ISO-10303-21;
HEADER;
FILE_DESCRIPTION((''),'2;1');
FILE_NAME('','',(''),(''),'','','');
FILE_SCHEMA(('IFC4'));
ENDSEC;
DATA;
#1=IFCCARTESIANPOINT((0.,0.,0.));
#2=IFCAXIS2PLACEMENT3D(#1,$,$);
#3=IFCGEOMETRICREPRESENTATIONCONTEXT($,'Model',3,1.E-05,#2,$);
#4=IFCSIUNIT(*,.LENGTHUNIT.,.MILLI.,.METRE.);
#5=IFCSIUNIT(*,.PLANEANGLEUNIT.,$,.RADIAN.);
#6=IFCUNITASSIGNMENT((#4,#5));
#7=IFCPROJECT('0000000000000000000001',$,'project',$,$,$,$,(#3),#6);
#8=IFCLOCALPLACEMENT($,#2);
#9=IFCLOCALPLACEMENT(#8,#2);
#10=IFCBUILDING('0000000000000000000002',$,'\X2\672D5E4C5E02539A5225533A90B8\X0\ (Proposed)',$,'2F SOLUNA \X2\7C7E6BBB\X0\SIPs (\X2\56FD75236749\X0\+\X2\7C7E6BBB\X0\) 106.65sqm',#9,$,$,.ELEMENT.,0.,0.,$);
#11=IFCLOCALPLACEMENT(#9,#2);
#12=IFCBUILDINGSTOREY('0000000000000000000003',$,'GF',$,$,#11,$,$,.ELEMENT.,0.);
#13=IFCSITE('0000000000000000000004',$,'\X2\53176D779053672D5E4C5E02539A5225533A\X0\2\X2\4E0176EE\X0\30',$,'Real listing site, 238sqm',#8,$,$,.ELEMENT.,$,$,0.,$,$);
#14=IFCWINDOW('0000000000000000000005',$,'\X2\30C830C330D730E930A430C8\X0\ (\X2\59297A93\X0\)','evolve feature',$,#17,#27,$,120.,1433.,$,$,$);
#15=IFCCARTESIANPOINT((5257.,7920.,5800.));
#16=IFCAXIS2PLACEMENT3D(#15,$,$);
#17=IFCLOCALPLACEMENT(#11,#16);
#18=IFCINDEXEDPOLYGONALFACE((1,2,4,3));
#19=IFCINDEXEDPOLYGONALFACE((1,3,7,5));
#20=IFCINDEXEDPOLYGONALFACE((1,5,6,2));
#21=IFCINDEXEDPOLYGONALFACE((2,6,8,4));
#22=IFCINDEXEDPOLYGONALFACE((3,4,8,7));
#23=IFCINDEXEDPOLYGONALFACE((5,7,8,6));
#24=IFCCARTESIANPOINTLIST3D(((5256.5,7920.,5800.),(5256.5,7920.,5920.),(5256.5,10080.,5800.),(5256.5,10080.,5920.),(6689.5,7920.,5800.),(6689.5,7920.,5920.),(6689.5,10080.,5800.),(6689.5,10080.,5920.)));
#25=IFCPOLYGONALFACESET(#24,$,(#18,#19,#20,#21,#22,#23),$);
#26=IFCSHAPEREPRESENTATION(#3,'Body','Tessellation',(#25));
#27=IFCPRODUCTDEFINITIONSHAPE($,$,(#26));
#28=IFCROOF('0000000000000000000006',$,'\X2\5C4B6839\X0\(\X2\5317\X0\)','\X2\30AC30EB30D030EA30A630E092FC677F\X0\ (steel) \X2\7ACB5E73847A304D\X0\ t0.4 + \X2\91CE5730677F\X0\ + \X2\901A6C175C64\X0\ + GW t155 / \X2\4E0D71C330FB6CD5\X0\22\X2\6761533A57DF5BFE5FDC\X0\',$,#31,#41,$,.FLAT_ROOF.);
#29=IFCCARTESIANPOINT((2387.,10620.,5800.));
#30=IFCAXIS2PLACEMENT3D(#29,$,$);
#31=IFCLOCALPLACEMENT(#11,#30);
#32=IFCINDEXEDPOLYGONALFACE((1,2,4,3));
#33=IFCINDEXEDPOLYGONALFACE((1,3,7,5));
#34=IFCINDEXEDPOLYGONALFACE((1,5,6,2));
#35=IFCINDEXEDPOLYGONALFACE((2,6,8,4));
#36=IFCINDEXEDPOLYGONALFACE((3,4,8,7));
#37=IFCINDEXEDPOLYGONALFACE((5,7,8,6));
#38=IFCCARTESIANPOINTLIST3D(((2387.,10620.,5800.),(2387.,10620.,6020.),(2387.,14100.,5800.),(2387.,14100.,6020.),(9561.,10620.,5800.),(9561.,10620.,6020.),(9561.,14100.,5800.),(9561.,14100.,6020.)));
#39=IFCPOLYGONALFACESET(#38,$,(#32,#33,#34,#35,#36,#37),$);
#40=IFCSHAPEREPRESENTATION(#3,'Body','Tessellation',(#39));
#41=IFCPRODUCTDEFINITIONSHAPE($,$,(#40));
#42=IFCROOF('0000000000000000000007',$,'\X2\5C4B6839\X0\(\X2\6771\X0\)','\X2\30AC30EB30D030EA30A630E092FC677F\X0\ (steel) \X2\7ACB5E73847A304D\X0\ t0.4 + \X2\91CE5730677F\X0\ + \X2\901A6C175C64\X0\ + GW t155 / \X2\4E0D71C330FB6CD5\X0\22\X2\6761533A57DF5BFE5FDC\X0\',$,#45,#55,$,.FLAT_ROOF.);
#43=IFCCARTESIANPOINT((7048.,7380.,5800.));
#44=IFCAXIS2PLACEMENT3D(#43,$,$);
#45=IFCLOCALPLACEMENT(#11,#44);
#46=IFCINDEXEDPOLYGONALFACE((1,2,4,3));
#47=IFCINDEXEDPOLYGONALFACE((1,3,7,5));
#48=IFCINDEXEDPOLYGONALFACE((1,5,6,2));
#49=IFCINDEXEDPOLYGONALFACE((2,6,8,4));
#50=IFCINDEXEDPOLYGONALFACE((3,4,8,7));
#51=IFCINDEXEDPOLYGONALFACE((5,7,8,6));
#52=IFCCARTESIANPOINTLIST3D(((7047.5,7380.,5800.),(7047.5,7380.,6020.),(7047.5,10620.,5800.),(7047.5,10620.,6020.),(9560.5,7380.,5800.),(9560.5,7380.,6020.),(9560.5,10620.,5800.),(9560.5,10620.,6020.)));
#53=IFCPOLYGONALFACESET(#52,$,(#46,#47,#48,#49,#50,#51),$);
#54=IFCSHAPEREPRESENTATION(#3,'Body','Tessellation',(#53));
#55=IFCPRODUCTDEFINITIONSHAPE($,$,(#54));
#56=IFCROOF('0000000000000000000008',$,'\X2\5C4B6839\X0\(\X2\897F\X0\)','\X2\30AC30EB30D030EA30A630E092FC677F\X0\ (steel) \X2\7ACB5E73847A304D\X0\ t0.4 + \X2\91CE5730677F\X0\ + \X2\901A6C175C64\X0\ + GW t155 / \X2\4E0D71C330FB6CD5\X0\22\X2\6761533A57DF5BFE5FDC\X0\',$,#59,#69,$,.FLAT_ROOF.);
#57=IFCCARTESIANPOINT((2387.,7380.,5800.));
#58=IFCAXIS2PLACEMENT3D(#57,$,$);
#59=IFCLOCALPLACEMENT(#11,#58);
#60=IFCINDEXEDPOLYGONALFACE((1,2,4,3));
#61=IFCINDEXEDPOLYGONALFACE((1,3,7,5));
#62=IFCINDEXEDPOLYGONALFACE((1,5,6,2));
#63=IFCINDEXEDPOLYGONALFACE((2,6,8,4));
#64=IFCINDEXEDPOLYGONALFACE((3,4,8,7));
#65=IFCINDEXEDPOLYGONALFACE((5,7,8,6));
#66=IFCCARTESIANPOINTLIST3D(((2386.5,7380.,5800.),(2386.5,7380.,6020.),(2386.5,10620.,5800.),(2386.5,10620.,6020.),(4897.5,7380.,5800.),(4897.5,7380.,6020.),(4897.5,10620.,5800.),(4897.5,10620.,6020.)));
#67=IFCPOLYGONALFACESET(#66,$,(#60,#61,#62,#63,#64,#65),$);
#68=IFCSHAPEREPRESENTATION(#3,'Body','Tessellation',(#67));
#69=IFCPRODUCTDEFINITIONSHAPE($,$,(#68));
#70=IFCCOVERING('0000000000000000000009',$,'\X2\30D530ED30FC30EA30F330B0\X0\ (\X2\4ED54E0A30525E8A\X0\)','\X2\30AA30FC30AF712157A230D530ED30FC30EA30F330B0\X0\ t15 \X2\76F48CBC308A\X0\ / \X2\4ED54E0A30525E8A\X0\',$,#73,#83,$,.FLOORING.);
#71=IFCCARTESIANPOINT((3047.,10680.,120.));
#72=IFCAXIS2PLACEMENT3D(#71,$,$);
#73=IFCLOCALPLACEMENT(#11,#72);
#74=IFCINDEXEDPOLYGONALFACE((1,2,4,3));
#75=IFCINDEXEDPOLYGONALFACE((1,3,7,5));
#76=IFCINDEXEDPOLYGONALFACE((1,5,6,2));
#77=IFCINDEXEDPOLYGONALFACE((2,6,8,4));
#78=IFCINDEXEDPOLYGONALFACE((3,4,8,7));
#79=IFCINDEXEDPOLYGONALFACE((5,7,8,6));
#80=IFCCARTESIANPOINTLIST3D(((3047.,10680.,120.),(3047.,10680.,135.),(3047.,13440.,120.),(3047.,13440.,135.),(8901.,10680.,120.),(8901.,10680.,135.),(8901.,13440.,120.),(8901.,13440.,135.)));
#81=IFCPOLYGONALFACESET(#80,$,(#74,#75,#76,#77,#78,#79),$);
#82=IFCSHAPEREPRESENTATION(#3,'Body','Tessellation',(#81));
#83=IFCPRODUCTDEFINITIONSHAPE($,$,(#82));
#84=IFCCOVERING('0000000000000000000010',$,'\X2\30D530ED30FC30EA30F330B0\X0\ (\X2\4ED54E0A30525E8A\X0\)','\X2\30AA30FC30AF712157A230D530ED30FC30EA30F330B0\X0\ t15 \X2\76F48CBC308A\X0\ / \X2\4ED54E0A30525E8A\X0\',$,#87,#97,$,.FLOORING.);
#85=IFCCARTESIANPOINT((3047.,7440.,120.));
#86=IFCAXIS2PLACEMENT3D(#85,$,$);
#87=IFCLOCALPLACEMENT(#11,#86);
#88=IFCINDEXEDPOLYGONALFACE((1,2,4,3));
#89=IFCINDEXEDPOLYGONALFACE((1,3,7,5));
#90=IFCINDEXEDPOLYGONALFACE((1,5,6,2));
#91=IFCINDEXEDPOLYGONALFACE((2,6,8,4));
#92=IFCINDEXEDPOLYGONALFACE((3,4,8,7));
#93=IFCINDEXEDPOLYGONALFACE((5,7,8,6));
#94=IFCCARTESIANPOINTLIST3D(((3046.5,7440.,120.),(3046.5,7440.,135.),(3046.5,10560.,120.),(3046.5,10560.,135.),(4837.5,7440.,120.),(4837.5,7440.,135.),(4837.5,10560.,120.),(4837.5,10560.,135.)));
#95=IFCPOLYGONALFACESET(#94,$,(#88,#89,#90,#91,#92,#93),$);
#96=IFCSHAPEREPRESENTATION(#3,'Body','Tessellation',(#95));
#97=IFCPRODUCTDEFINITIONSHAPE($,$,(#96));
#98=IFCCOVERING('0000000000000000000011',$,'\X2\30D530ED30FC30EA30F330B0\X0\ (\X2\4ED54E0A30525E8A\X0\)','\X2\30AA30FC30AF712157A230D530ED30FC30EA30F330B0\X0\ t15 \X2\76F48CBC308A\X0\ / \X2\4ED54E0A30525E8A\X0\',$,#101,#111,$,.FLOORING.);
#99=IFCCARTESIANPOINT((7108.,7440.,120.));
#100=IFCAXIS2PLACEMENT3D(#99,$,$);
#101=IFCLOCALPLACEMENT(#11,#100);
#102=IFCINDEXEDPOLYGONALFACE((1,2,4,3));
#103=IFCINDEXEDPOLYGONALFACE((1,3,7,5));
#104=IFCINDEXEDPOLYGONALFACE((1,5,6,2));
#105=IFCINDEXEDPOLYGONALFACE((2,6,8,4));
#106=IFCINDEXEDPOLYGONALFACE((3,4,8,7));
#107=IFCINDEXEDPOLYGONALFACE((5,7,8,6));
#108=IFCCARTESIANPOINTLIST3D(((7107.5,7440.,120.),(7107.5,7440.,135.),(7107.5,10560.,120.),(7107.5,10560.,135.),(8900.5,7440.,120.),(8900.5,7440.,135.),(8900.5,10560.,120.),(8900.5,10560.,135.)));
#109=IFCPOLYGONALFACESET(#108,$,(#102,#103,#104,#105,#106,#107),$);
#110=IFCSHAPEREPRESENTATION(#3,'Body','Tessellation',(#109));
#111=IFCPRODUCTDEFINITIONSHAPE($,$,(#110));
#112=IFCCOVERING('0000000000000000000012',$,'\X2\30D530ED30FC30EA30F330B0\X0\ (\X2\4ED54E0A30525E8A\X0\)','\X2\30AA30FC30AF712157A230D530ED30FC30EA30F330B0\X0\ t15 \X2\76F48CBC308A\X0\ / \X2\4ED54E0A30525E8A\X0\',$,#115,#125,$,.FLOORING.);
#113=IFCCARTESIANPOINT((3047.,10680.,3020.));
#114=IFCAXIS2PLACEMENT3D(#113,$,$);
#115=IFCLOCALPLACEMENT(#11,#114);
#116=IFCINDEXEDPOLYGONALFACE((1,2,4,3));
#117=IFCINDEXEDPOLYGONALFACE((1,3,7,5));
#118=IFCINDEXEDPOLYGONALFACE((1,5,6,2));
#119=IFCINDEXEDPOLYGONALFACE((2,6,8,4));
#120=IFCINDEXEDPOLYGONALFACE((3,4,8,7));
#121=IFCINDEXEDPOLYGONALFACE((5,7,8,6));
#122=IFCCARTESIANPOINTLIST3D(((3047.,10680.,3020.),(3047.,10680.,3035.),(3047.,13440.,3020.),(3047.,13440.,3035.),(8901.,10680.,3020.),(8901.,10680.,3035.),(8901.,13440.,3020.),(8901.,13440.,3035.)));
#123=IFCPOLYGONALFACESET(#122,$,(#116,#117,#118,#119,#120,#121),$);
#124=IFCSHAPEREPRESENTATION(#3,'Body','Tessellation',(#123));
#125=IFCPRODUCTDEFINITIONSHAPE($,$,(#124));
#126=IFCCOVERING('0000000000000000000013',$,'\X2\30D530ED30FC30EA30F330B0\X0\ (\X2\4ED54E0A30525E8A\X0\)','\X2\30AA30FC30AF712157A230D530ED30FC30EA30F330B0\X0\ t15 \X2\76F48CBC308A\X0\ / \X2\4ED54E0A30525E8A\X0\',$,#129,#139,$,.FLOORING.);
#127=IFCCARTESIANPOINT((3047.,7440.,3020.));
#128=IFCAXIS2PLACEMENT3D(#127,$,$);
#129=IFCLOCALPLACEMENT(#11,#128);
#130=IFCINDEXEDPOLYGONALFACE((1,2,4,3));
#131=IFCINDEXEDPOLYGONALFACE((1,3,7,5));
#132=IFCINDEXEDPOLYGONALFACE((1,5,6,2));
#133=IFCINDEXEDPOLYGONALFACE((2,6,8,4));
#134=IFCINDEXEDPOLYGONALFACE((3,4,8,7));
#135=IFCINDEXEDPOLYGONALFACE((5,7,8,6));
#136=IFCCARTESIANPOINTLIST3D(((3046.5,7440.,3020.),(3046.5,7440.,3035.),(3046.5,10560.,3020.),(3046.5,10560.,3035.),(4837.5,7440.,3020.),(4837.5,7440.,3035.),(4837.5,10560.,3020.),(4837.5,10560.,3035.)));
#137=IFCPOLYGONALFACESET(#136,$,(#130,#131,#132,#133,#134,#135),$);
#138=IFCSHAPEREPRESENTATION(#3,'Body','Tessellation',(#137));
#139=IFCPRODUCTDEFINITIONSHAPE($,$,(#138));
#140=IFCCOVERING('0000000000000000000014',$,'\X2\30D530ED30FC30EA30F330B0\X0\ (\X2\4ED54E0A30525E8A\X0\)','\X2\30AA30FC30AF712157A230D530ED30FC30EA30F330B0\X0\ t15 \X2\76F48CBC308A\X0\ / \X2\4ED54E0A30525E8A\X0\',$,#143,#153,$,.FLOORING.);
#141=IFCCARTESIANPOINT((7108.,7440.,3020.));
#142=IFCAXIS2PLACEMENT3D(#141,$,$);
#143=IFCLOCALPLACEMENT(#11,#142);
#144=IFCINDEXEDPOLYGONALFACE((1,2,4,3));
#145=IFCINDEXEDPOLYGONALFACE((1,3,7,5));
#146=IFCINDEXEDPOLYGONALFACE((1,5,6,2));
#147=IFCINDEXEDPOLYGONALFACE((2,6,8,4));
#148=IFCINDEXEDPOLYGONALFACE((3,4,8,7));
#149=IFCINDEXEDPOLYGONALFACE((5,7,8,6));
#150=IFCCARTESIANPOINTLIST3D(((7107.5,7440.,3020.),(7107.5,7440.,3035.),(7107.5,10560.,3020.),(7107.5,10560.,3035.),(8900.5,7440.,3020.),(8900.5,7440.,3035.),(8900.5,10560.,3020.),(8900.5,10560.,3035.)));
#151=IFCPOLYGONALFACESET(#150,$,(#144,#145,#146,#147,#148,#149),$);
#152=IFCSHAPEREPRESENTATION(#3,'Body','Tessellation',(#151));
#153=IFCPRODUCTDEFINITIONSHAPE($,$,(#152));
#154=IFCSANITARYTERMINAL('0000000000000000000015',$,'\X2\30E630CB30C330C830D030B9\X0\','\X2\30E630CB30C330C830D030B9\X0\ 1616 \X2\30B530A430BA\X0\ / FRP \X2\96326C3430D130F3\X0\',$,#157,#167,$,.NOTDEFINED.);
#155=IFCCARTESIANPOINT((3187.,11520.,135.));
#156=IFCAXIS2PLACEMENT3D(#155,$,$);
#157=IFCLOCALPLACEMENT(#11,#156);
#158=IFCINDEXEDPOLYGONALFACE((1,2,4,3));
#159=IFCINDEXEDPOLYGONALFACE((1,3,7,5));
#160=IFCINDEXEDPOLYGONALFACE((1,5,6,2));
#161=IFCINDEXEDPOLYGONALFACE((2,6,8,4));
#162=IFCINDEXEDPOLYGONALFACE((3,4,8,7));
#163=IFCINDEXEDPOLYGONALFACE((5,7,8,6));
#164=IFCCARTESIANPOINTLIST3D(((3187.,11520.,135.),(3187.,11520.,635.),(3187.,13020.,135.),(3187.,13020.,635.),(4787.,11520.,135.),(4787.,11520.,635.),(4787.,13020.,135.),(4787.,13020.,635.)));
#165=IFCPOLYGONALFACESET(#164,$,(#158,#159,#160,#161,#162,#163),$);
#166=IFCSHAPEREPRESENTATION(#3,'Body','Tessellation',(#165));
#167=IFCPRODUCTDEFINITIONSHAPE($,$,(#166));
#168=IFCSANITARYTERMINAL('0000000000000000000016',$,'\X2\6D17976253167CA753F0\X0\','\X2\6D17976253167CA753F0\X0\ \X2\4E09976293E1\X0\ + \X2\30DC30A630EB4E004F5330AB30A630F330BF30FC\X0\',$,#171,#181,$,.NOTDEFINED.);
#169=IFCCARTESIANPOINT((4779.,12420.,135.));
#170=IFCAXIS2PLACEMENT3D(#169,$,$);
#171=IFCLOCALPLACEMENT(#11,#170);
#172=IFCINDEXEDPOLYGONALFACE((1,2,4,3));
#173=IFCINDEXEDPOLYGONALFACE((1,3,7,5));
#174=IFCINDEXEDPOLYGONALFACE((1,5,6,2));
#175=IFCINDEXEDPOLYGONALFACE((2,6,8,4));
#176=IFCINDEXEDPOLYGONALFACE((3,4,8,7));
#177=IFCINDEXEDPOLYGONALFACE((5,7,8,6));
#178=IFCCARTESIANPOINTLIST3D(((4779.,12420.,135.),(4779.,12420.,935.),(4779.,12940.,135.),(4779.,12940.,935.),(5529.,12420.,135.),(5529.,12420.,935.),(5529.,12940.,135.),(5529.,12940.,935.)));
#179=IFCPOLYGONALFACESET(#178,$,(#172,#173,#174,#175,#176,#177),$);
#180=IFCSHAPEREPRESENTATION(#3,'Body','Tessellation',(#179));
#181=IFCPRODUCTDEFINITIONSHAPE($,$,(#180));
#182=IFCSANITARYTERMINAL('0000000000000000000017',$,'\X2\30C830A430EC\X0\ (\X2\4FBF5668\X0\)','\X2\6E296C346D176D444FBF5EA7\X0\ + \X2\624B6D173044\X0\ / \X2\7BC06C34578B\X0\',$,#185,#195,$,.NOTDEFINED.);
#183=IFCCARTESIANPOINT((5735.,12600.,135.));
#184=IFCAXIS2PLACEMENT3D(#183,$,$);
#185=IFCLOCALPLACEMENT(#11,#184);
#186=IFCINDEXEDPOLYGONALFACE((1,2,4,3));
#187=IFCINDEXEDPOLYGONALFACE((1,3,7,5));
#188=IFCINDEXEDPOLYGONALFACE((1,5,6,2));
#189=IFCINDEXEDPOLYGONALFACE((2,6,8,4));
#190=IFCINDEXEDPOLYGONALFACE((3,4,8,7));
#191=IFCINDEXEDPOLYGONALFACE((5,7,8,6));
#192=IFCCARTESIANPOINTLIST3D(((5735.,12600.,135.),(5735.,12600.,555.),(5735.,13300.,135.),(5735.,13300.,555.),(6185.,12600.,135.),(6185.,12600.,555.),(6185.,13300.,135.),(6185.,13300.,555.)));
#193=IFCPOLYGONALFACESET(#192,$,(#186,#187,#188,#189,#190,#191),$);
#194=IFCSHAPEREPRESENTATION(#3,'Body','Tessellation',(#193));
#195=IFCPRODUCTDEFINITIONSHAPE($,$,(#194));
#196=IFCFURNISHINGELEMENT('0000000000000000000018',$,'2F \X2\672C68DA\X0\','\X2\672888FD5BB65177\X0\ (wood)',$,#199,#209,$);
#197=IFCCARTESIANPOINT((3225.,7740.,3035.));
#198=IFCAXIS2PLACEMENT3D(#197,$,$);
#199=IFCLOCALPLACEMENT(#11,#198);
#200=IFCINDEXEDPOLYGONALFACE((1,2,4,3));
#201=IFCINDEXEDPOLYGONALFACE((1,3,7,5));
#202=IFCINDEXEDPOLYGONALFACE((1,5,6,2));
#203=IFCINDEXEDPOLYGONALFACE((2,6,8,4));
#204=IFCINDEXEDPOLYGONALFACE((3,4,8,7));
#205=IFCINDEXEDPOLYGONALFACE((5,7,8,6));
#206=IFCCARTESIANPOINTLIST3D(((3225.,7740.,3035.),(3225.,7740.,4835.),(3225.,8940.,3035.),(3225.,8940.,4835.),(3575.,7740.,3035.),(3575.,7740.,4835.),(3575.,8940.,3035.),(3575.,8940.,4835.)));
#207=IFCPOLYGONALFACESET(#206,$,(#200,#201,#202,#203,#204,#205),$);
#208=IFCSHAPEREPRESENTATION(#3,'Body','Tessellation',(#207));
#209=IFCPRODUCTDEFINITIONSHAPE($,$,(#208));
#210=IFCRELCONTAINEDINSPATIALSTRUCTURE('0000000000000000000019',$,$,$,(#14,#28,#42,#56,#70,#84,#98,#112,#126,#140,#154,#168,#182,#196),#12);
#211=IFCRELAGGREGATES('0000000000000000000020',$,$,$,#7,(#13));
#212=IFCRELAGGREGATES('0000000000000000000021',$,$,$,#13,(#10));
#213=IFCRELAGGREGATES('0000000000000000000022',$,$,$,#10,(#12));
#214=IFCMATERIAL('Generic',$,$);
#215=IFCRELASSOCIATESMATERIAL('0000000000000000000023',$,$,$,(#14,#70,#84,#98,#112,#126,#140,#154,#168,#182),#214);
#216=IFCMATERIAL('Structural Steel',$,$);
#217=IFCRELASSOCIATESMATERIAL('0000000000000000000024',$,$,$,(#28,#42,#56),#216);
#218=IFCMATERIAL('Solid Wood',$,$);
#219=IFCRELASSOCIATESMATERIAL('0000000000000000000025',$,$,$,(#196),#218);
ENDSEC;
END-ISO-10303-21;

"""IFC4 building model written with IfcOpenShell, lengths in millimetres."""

from ifc_helpers import new_model, si_unit, frame, frame_2d, origin, place, context, project, spatial, rectangle, extrude, material, element, save


model = new_model("IFC4")

# Units and contexts
model_context = context("Model", 3, precision=1e-05, world=origin())
ifc_project = project(units=[si_unit("LENGTHUNIT", "METRE", prefix="MILLI"), si_unit("PLANEANGLEUNIT", "RADIAN")], contexts=[model_context])

# Site, building, storey
site_placement = place(None, origin())
site = spatial("IfcSite", under=ifc_project, at=site_placement, Name="北海道札幌市厚別区2丁目30", ObjectType="Real listing site, 238sqm", CompositionType="ELEMENT", RefElevation=0.0)
building_placement = place(site_placement, origin())
building = spatial("IfcBuilding", under=site, at=building_placement, Name="札幌市厚別区邸 (Proposed)", ObjectType="2F SOLUNA 籾殻SIPs (国産杉+籾殻) 106.65sqm", CompositionType="ELEMENT", ElevationOfRefHeight=0.0, ElevationOfTerrain=0.0)
storey_placement = place(building_placement, origin())
storey = spatial("IfcBuildingStorey", under=building, at=storey_placement, Name="GF", CompositionType="ELEMENT", Elevation=0.0)

# Shared definitions
ifc_material_1 = material(Name="Solid Wood")

# Window
ifc_material_2 = material(Name="Generic")
window_1_placement = place(storey_placement, frame((5257.0, 7920.0, 5800.0)))
element("IfcWindow", 1, at=window_1_placement, inside=storey, material=ifc_material_2, Name="トップライト (天窓)", Description="evolve feature", OverallHeight=120.0, OverallWidth=1433.0, context=model_context, shape_type="SweptSolid", body=[
    extrude(rectangle(XDim=1433.0, YDim=2160.0, at=frame_2d((716.0, 1080.0))), frame((5257.0, 7920.0, 5800.0)), (0.0, 0.0, 1.0), 120.0),
])

# Roofs
ifc_material_3 = material(Name="Structural Steel")
roof_1_placement = place(storey_placement, frame((2387.0, 10620.0, 5800.0)))
element("IfcRoof", 2, at=roof_1_placement, inside=storey, material=ifc_material_3, Name="屋根(北)", Description="ガルバリウム鋼板 (steel) 立平葺き t0.4 + 野地板 + 通気層 + GW t155 / 不燃・法22条区域対応", PredefinedType="FLAT_ROOF", context=model_context, shape_type="SweptSolid", body=[
    extrude(rectangle(XDim=7174.0, YDim=3480.0, at=frame_2d((3587.0, 1740.0))), frame((2387.0, 10620.0, 5800.0)), (0.0, 0.0, 1.0), 220.0),
])
roof_2_placement = place(storey_placement, frame((7048.0, 7380.0, 5800.0)))
element("IfcRoof", 3, at=roof_2_placement, inside=storey, material=ifc_material_3, Name="屋根(東)", Description="ガルバリウム鋼板 (steel) 立平葺き t0.4 + 野地板 + 通気層 + GW t155 / 不燃・法22条区域対応", PredefinedType="FLAT_ROOF", context=model_context, shape_type="SweptSolid", body=[
    extrude(rectangle(XDim=2513.0, YDim=3240.0, at=frame_2d((1256.0, 1620.0))), frame((7048.0, 7380.0, 5800.0)), (0.0, 0.0, 1.0), 220.0),
])
roof_3_placement = place(storey_placement, frame((2387.0, 7380.0, 5800.0)))
element("IfcRoof", 4, at=roof_3_placement, inside=storey, material=ifc_material_3, Name="屋根(西)", Description="ガルバリウム鋼板 (steel) 立平葺き t0.4 + 野地板 + 通気層 + GW t155 / 不燃・法22条区域対応", PredefinedType="FLAT_ROOF", context=model_context, shape_type="SweptSolid", body=[
    extrude(rectangle(XDim=2511.0, YDim=3240.0, at=frame_2d((1255.0, 1620.0))), frame((2387.0, 7380.0, 5800.0)), (0.0, 0.0, 1.0), 220.0),
])

# Coverings
covering_1_placement = place(storey_placement, frame((3047.0, 10680.0, 120.0)))
element("IfcCovering", 5, at=covering_1_placement, inside=storey, material=ifc_material_2, Name="フローリング (仕上げ床)", Description="オーク無垢フローリング t15 直貼り / 仕上げ床", PredefinedType="FLOORING", context=model_context, shape_type="SweptSolid", body=[
    extrude(rectangle(XDim=5854.0, YDim=2760.0, at=frame_2d((2927.0, 1380.0))), frame((3047.0, 10680.0, 120.0)), (0.0, 0.0, 1.0), 15.0),
])
covering_2_placement = place(storey_placement, frame((3047.0, 7440.0, 120.0)))
element("IfcCovering", 6, at=covering_2_placement, inside=storey, material=ifc_material_2, Name="フローリング (仕上げ床)", Description="オーク無垢フローリング t15 直貼り / 仕上げ床", PredefinedType="FLOORING", context=model_context, shape_type="SweptSolid", body=[
    extrude(rectangle(XDim=1791.0, YDim=3120.0, at=frame_2d((895.0, 1560.0))), frame((3047.0, 7440.0, 120.0)), (0.0, 0.0, 1.0), 15.0),
])
covering_3_placement = place(storey_placement, frame((7108.0, 7440.0, 120.0)))
element("IfcCovering", 7, at=covering_3_placement, inside=storey, material=ifc_material_2, Name="フローリング (仕上げ床)", Description="オーク無垢フローリング t15 直貼り / 仕上げ床", PredefinedType="FLOORING", context=model_context, shape_type="SweptSolid", body=[
    extrude(rectangle(XDim=1793.0, YDim=3120.0, at=frame_2d((896.0, 1560.0))), frame((7108.0, 7440.0, 120.0)), (0.0, 0.0, 1.0), 15.0),
])
covering_4_placement = place(storey_placement, frame((3047.0, 10680.0, 3020.0)))
element("IfcCovering", 8, at=covering_4_placement, inside=storey, material=ifc_material_2, Name="フローリング (仕上げ床)", Description="オーク無垢フローリング t15 直貼り / 仕上げ床", PredefinedType="FLOORING", context=model_context, shape_type="SweptSolid", body=[
    extrude(rectangle(XDim=5854.0, YDim=2760.0, at=frame_2d((2927.0, 1380.0))), frame((3047.0, 10680.0, 3020.0)), (0.0, 0.0, 1.0), 15.0),
])
covering_5_placement = place(storey_placement, frame((3047.0, 7440.0, 3020.0)))
element("IfcCovering", 9, at=covering_5_placement, inside=storey, material=ifc_material_2, Name="フローリング (仕上げ床)", Description="オーク無垢フローリング t15 直貼り / 仕上げ床", PredefinedType="FLOORING", context=model_context, shape_type="SweptSolid", body=[
    extrude(rectangle(XDim=1791.0, YDim=3120.0, at=frame_2d((895.0, 1560.0))), frame((3047.0, 7440.0, 3020.0)), (0.0, 0.0, 1.0), 15.0),
])
covering_6_placement = place(storey_placement, frame((7108.0, 7440.0, 3020.0)))
element("IfcCovering", 10, at=covering_6_placement, inside=storey, material=ifc_material_2, Name="フローリング (仕上げ床)", Description="オーク無垢フローリング t15 直貼り / 仕上げ床", PredefinedType="FLOORING", context=model_context, shape_type="SweptSolid", body=[
    extrude(rectangle(XDim=1793.0, YDim=3120.0, at=frame_2d((896.0, 1560.0))), frame((7108.0, 7440.0, 3020.0)), (0.0, 0.0, 1.0), 15.0),
])

# Sanitary terminals
sanitary_terminal_1_placement = place(storey_placement, frame((3187.0, 11520.0, 135.0)))
element("IfcSanitaryTerminal", 11, at=sanitary_terminal_1_placement, inside=storey, material=ifc_material_2, Name="ユニットバス", Description="ユニットバス 1616 サイズ / FRP 防水パン", PredefinedType="NOTDEFINED", context=model_context, shape_type="SweptSolid", body=[
    extrude(rectangle(XDim=1600.0, YDim=1500.0, at=frame_2d((800.0, 750.0))), frame((3187.0, 11520.0, 135.0)), (0.0, 0.0, 1.0), 500.0),
])
sanitary_terminal_2_placement = place(storey_placement, frame((4779.0, 12420.0, 135.0)))
element("IfcSanitaryTerminal", 12, at=sanitary_terminal_2_placement, inside=storey, material=ifc_material_2, Name="洗面化粧台", Description="洗面化粧台 三面鏡 + ボウル一体カウンター", PredefinedType="NOTDEFINED", context=model_context, shape_type="SweptSolid", body=[
    extrude(rectangle(XDim=750.0, YDim=520.0, at=frame_2d((375.0, 260.0))), frame((4779.0, 12420.0, 135.0)), (0.0, 0.0, 1.0), 800.0),
])
sanitary_terminal_3_placement = place(storey_placement, frame((5735.0, 12600.0, 135.0)))
element("IfcSanitaryTerminal", 13, at=sanitary_terminal_3_placement, inside=storey, material=ifc_material_2, Name="トイレ (便器)", Description="温水洗浄便座 + 手洗い / 節水型", PredefinedType="NOTDEFINED", context=model_context, shape_type="SweptSolid", body=[
    extrude(rectangle(XDim=450.0, YDim=700.0, at=frame_2d((225.0, 350.0))), frame((5735.0, 12600.0, 135.0)), (0.0, 0.0, 1.0), 420.0),
])

# Furnishing element
furnishing_placement = place(storey_placement, frame((3225.0, 7740.0, 3035.0)))
element("IfcFurnishingElement", 14, at=furnishing_placement, inside=storey, material=ifc_material_1, Name="2F 本棚", Description="木製家具 (wood)", context=model_context, shape_type="SweptSolid", body=[
    extrude(rectangle(XDim=350.0, YDim=1200.0, at=frame_2d((175.0, 600.0))), frame((3225.0, 7740.0, 3035.0)), (0.0, 0.0, 1.0), 1800.0),
])

save(model, "model.ifc")
